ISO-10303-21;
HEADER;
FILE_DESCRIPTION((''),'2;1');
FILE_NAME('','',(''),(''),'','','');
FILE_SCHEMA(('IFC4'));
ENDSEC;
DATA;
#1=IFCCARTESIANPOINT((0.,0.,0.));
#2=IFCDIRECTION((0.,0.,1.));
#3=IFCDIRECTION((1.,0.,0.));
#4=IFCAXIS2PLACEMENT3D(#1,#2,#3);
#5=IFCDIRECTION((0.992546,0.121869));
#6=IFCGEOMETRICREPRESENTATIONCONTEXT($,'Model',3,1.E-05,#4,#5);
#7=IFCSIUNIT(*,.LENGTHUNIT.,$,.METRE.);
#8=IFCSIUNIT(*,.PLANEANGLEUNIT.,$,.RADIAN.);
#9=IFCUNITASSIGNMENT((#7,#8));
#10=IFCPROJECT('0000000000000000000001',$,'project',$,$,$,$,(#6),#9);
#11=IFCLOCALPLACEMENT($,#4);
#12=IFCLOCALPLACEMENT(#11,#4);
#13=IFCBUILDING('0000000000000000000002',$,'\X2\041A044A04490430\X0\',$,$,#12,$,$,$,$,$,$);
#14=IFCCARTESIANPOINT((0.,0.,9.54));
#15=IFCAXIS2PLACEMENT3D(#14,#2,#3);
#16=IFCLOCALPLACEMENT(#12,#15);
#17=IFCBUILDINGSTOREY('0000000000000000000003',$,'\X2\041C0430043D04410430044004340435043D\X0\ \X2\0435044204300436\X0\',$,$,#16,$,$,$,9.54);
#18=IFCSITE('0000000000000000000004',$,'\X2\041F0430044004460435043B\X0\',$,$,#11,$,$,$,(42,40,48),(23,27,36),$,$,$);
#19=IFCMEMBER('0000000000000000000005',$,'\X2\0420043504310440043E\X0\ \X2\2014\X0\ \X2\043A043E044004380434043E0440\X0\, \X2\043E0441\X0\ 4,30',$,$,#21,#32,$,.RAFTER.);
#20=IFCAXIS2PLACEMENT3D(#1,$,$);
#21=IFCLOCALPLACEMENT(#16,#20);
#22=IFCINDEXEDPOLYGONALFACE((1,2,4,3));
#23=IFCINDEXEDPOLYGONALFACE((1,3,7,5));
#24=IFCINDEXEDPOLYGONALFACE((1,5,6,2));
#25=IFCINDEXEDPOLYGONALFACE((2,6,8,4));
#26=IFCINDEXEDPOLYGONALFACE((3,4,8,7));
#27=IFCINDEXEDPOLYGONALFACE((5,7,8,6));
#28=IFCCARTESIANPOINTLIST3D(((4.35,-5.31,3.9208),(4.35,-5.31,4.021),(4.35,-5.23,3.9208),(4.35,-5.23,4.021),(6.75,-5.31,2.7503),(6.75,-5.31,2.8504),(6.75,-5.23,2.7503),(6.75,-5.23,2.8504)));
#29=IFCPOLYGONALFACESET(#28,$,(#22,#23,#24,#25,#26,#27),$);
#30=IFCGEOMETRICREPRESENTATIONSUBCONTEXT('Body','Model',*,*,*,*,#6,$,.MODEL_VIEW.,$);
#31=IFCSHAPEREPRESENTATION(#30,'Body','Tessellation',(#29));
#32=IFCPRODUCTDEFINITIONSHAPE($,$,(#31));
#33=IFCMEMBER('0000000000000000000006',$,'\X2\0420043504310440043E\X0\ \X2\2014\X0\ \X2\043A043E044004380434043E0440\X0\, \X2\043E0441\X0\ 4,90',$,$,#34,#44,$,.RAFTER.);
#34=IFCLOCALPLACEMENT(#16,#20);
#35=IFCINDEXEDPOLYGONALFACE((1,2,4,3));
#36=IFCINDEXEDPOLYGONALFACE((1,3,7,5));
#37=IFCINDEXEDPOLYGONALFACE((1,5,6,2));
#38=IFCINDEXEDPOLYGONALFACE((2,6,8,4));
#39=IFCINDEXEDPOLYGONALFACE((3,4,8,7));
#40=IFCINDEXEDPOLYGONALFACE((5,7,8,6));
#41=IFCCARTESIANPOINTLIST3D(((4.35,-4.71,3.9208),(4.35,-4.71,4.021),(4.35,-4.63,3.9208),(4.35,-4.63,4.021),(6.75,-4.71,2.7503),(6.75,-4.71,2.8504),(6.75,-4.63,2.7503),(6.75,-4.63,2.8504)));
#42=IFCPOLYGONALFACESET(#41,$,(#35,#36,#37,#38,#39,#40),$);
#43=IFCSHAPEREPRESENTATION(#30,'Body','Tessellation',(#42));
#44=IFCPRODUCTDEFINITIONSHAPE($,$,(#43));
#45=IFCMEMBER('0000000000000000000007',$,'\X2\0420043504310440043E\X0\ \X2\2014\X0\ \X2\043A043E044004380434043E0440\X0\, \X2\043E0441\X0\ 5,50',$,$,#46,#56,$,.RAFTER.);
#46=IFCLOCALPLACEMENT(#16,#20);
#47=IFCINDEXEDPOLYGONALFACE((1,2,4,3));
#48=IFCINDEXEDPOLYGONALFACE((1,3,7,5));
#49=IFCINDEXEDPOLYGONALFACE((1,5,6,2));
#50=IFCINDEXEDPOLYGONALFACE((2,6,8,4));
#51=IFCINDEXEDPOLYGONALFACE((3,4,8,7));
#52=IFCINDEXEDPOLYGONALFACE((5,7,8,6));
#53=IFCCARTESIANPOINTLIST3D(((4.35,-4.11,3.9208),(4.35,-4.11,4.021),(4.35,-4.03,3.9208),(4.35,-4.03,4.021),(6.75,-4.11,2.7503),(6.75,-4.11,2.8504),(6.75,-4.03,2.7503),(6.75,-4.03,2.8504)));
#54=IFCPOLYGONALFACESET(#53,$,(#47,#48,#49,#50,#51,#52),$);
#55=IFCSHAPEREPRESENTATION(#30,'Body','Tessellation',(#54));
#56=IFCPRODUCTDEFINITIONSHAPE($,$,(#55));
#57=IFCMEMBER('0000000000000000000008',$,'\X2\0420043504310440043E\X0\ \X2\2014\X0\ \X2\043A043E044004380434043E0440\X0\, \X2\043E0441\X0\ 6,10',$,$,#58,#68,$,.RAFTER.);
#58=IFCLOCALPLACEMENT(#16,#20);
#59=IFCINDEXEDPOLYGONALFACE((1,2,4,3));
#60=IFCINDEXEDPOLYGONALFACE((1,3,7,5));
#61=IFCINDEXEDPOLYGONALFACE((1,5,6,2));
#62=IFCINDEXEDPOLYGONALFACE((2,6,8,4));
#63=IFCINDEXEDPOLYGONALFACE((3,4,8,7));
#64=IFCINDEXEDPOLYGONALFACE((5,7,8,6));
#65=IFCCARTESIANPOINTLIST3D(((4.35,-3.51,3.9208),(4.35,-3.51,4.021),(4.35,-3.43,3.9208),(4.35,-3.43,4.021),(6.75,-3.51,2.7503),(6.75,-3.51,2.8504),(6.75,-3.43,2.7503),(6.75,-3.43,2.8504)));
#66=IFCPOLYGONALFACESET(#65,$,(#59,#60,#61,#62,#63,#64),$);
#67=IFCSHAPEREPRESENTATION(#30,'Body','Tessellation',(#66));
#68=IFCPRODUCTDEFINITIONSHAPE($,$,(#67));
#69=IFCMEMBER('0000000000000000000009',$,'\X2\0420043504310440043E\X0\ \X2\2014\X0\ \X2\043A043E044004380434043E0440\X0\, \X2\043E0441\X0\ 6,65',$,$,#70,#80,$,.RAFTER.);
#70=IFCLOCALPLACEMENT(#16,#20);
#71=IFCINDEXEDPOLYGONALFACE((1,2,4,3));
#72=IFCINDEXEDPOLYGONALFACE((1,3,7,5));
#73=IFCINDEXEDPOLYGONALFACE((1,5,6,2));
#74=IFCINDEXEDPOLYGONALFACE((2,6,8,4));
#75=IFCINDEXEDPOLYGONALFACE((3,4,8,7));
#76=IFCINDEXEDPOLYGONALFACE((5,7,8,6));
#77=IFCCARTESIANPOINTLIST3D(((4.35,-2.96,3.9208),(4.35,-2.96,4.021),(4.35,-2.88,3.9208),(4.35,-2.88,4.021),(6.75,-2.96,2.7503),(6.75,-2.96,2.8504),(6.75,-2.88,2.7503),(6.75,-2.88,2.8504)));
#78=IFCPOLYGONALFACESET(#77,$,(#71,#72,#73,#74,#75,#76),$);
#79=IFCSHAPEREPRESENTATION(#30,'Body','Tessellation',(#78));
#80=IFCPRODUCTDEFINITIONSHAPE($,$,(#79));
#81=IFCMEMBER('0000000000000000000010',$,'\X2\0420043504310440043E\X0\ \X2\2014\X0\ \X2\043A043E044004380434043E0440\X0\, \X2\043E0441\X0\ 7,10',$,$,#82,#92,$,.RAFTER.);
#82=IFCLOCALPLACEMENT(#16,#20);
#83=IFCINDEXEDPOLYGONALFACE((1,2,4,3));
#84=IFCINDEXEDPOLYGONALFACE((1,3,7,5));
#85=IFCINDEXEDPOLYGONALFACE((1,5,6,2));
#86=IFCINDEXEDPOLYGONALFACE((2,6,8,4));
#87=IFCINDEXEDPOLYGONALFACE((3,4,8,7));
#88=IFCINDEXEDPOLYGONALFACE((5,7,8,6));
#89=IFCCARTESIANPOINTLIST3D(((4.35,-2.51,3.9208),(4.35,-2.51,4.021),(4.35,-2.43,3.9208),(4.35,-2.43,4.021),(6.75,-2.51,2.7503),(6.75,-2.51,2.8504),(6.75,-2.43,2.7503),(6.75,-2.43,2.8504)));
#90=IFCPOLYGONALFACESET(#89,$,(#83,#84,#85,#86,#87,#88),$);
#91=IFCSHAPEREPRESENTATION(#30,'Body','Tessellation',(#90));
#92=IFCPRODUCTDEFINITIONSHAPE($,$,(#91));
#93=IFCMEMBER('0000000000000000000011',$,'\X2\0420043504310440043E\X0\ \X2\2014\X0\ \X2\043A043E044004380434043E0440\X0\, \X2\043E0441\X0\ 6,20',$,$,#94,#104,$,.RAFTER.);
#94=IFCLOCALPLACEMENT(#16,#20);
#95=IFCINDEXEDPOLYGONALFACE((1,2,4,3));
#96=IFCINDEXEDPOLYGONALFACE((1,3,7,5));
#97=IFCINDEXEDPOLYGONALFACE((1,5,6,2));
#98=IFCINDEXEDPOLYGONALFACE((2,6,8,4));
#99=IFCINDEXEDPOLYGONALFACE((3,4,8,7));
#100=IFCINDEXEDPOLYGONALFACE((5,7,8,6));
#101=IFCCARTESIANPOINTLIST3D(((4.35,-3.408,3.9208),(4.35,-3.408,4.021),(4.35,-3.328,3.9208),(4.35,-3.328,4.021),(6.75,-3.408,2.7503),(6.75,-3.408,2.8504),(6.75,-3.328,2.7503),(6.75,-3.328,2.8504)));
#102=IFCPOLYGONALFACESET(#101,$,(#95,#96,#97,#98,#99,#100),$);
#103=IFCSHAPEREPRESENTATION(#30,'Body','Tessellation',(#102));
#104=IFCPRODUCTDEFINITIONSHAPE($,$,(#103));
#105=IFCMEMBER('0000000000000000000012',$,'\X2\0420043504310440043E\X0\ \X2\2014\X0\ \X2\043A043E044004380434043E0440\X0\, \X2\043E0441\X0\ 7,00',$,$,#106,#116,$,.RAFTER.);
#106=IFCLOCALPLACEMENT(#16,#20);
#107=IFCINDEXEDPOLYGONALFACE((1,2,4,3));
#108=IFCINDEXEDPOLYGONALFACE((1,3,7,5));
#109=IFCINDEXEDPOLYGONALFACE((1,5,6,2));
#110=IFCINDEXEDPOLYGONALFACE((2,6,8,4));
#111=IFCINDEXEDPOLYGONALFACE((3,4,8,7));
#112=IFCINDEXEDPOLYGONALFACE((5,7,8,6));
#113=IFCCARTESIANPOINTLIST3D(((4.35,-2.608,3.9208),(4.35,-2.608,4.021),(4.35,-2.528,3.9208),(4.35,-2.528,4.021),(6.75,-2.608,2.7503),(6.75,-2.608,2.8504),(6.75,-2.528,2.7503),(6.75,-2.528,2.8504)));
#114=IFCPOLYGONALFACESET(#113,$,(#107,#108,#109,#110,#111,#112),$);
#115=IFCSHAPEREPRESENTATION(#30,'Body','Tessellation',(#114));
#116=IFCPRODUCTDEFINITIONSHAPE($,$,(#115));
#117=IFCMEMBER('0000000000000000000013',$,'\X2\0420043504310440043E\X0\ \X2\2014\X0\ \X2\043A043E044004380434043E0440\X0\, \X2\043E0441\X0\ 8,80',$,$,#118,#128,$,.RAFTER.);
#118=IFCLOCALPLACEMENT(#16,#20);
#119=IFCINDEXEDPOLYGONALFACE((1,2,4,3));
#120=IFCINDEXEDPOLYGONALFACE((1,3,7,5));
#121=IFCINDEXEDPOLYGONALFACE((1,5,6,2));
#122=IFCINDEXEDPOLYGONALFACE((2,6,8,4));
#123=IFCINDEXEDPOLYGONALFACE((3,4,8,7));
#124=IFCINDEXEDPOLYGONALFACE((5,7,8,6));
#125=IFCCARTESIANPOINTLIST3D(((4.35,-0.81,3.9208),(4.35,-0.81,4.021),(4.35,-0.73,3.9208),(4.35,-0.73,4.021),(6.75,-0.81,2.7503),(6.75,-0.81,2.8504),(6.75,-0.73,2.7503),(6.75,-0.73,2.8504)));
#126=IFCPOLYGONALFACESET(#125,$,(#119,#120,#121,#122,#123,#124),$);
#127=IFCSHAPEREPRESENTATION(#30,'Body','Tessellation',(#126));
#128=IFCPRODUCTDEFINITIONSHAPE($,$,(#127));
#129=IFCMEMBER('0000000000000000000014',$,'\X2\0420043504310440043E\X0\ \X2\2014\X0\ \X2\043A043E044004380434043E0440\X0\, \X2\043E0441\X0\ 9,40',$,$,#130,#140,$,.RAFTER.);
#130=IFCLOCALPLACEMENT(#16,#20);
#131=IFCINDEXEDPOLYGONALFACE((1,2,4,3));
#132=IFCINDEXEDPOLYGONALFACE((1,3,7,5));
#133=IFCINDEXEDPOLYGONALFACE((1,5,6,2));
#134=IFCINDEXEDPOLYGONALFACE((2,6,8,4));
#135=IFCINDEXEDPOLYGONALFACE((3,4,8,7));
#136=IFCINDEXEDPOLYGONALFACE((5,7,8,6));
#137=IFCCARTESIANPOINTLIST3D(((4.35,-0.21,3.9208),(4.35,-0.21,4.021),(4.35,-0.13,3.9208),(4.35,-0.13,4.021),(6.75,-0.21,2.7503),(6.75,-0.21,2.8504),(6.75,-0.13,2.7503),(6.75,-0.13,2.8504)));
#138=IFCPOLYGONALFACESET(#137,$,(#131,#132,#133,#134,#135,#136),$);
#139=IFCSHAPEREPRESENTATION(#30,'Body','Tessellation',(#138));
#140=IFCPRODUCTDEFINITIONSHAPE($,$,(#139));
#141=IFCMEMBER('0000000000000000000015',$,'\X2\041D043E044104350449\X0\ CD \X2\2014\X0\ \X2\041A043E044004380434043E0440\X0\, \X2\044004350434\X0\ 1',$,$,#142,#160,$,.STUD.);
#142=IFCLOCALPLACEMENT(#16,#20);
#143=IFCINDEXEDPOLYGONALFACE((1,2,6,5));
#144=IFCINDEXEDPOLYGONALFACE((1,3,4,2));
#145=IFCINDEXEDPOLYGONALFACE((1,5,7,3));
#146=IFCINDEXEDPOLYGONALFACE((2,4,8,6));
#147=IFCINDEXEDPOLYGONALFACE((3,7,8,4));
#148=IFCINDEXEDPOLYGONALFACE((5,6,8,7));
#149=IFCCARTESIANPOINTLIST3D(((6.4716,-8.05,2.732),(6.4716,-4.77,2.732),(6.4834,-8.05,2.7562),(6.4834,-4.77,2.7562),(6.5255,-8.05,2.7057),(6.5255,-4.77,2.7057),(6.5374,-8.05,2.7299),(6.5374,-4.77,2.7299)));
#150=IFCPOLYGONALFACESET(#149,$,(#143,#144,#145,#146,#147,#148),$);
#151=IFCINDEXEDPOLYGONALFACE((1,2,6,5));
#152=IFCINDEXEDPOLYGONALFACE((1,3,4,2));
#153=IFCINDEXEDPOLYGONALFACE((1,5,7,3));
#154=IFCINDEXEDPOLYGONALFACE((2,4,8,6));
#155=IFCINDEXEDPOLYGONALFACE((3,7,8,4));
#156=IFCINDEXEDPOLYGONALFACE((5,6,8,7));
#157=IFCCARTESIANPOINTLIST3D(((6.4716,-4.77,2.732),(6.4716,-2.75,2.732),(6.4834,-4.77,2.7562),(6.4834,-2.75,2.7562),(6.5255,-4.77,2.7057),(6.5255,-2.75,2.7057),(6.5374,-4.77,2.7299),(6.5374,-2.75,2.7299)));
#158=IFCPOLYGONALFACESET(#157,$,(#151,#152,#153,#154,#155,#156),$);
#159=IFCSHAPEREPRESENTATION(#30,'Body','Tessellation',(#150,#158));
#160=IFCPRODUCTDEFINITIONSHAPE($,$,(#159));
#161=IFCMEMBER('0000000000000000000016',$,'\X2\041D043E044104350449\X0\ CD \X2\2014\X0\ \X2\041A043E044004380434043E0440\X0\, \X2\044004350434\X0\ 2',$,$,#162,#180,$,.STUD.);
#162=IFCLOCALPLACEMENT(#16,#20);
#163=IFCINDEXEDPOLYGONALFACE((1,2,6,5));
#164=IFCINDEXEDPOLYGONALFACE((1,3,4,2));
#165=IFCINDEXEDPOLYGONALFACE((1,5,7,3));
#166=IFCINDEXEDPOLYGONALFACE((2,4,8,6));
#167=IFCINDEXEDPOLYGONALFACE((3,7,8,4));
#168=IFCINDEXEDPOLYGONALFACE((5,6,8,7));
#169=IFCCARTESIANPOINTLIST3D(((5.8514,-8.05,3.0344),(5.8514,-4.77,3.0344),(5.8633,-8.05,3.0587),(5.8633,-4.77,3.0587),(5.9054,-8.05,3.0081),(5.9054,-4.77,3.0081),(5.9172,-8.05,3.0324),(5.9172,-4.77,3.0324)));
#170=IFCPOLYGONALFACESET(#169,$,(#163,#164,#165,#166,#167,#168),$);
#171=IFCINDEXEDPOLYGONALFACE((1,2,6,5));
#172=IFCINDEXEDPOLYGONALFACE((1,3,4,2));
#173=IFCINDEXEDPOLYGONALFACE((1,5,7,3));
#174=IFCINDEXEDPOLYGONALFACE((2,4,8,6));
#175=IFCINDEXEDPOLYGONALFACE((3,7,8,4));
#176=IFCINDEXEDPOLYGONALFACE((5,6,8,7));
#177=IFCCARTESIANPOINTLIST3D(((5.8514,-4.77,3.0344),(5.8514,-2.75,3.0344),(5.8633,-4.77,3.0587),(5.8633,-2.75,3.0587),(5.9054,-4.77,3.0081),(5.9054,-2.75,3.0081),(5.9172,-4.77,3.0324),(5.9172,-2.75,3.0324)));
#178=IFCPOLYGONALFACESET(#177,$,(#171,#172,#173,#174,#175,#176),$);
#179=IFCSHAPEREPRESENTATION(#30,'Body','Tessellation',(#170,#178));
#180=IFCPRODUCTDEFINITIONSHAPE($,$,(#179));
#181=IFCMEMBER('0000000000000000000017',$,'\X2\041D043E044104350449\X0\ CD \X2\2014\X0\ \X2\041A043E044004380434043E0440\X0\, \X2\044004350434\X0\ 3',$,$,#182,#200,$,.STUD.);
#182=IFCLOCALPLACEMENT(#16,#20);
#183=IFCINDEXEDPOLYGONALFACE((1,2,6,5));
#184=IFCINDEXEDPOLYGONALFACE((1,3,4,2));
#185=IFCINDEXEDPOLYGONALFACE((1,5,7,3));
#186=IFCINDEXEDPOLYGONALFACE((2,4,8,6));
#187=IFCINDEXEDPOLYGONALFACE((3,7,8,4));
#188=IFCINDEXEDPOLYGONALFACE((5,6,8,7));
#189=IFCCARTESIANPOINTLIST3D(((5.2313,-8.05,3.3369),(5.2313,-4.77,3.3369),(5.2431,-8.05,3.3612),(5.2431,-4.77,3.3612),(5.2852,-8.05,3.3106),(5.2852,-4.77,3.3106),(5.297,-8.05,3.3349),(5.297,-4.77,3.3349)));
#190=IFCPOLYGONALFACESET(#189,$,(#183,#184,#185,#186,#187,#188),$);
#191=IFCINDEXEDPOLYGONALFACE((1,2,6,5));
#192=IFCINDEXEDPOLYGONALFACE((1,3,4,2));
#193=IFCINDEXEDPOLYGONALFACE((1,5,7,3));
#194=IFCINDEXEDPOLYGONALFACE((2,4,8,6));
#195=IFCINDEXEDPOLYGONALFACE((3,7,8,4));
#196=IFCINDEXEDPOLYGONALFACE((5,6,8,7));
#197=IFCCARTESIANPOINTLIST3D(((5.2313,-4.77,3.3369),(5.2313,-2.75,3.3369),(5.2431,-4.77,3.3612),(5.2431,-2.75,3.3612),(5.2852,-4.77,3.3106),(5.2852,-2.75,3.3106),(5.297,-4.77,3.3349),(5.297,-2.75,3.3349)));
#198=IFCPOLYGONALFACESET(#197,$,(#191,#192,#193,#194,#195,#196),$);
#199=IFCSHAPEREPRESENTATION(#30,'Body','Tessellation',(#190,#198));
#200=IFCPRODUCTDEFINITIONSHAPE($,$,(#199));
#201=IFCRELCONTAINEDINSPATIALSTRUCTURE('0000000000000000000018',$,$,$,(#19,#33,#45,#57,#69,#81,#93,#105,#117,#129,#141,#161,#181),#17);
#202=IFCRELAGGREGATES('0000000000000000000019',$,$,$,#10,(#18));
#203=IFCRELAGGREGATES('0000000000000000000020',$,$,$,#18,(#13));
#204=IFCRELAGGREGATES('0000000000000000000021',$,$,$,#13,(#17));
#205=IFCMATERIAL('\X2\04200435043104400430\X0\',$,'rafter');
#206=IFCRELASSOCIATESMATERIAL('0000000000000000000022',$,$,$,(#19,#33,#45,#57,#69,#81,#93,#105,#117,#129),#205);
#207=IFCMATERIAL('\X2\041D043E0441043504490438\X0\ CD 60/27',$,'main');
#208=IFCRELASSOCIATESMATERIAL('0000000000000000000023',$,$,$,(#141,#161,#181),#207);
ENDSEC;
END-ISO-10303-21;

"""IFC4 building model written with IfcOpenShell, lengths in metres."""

from ifc_helpers import new_model, si_unit, direction, frame, origin_with_axes, place, context, subcontext, project, spatial, polyline, outline, extrude, material, element, save


model = new_model("IFC4")

# Units and contexts
model_context = context("Model", 3, precision=1e-05, world=origin_with_axes(), true_north=direction((0.992546, 0.121869)))
body_context = subcontext(model_context, "Body", "Model", "MODEL_VIEW")
ifc_project = project(units=[si_unit("LENGTHUNIT", "METRE"), si_unit("PLANEANGLEUNIT", "RADIAN")], contexts=[model_context])

# Site, building, storey
site_placement = place(None, origin_with_axes())
site = spatial("IfcSite", under=ifc_project, at=site_placement, Name="Парцел", RefLatitude=(42, 40, 48), RefLongitude=(23, 27, 36))
building_placement = place(site_placement, origin_with_axes())
building = spatial("IfcBuilding", under=site, at=building_placement, Name="Къща")
storey_placement = place(building_placement, frame((0.0, 0.0, 9.54), z_axis=(0.0, 0.0, 1.0), x_axis=(1.0, 0.0, 0.0)))
storey = spatial("IfcBuildingStorey", under=building, at=storey_placement, Name="Мансарден етаж", Elevation=9.54)

# Members
ifc_material_1 = material(Name="Ребра", Category="rafter")
member_1_placement = place(storey_placement, origin_with_axes())
element("IfcMember", 1, at=member_1_placement, inside=storey, material=ifc_material_1, Name="Ребро — коридор, ос 4,30", PredefinedType="RAFTER", context=body_context, shape_type="SweptSolid", body=[
    extrude(outline(polyline([(6.75, -2.7503), (4.35, -3.9208), (4.35, -4.021), (6.75, -2.8504), (6.75, -2.7503)])), frame((0.0, -5.31, 0.0), z_axis=(0.0, 1.0, 0.0), x_axis=(1.0, 0.0, 0.0)), (0.0, 0.0, 1.0), 0.08),
])
member_2_placement = place(storey_placement, origin_with_axes())
element("IfcMember", 2, at=member_2_placement, inside=storey, material=ifc_material_1, Name="Ребро — коридор, ос 4,90", PredefinedType="RAFTER", context=body_context, shape_type="SweptSolid", body=[
    extrude(outline(polyline([(6.75, -2.7503), (4.35, -3.9208), (4.35, -4.021), (6.75, -2.8504), (6.75, -2.7503)])), frame((0.0, -4.71, 0.0), z_axis=(0.0, 1.0, 0.0), x_axis=(1.0, 0.0, 0.0)), (0.0, 0.0, 1.0), 0.08),
])
member_3_placement = place(storey_placement, origin_with_axes())
element("IfcMember", 3, at=member_3_placement, inside=storey, material=ifc_material_1, Name="Ребро — коридор, ос 5,50", PredefinedType="RAFTER", context=body_context, shape_type="SweptSolid", body=[
    extrude(outline(polyline([(6.75, -2.7503), (4.35, -3.9208), (4.35, -4.021), (6.75, -2.8504), (6.75, -2.7503)])), frame((0.0, -4.11, 0.0), z_axis=(0.0, 1.0, 0.0), x_axis=(1.0, 0.0, 0.0)), (0.0, 0.0, 1.0), 0.08),
])
member_4_placement = place(storey_placement, origin_with_axes())
element("IfcMember", 4, at=member_4_placement, inside=storey, material=ifc_material_1, Name="Ребро — коридор, ос 6,10", PredefinedType="RAFTER", context=body_context, shape_type="SweptSolid", body=[
    extrude(outline(polyline([(6.75, -2.7503), (4.35, -3.9208), (4.35, -4.021), (6.75, -2.8504), (6.75, -2.7503)])), frame((0.0, -3.51, 0.0), z_axis=(0.0, 1.0, 0.0), x_axis=(1.0, 0.0, 0.0)), (0.0, 0.0, 1.0), 0.08),
])
member_5_placement = place(storey_placement, origin_with_axes())
element("IfcMember", 5, at=member_5_placement, inside=storey, material=ifc_material_1, Name="Ребро — коридор, ос 6,65", PredefinedType="RAFTER", context=body_context, shape_type="SweptSolid", body=[
    extrude(outline(polyline([(6.75, -2.7503), (4.35, -3.9208), (4.35, -4.021), (6.75, -2.8504), (6.75, -2.7503)])), frame((0.0, -2.96, 0.0), z_axis=(0.0, 1.0, 0.0), x_axis=(1.0, 0.0, 0.0)), (0.0, 0.0, 1.0), 0.08),
])
member_6_placement = place(storey_placement, origin_with_axes())
element("IfcMember", 6, at=member_6_placement, inside=storey, material=ifc_material_1, Name="Ребро — коридор, ос 7,10", PredefinedType="RAFTER", context=body_context, shape_type="SweptSolid", body=[
    extrude(outline(polyline([(6.75, -2.7503), (4.35, -3.9208), (4.35, -4.021), (6.75, -2.8504), (6.75, -2.7503)])), frame((0.0, -2.51, 0.0), z_axis=(0.0, 1.0, 0.0), x_axis=(1.0, 0.0, 0.0)), (0.0, 0.0, 1.0), 0.08),
])
member_7_placement = place(storey_placement, origin_with_axes())
element("IfcMember", 7, at=member_7_placement, inside=storey, material=ifc_material_1, Name="Ребро — коридор, ос 6,20", PredefinedType="RAFTER", context=body_context, shape_type="SweptSolid", body=[
    extrude(outline(polyline([(6.75, -2.7503), (4.35, -3.9208), (4.35, -4.021), (6.75, -2.8504), (6.75, -2.7503)])), frame((0.0, -3.408, 0.0), z_axis=(0.0, 1.0, 0.0), x_axis=(1.0, 0.0, 0.0)), (0.0, 0.0, 1.0), 0.08),
])
member_8_placement = place(storey_placement, origin_with_axes())
element("IfcMember", 8, at=member_8_placement, inside=storey, material=ifc_material_1, Name="Ребро — коридор, ос 7,00", PredefinedType="RAFTER", context=body_context, shape_type="SweptSolid", body=[
    extrude(outline(polyline([(6.75, -2.7503), (4.35, -3.9208), (4.35, -4.021), (6.75, -2.8504), (6.75, -2.7503)])), frame((0.0, -2.608, 0.0), z_axis=(0.0, 1.0, 0.0), x_axis=(1.0, 0.0, 0.0)), (0.0, 0.0, 1.0), 0.08),
])
member_9_placement = place(storey_placement, origin_with_axes())
element("IfcMember", 9, at=member_9_placement, inside=storey, material=ifc_material_1, Name="Ребро — коридор, ос 8,80", PredefinedType="RAFTER", context=body_context, shape_type="SweptSolid", body=[
    extrude(outline(polyline([(6.75, -2.7503), (4.35, -3.9208), (4.35, -4.021), (6.75, -2.8504), (6.75, -2.7503)])), frame((0.0, -0.81, 0.0), z_axis=(0.0, 1.0, 0.0), x_axis=(1.0, 0.0, 0.0)), (0.0, 0.0, 1.0), 0.08),
])
member_10_placement = place(storey_placement, origin_with_axes())
element("IfcMember", 10, at=member_10_placement, inside=storey, material=ifc_material_1, Name="Ребро — коридор, ос 9,40", PredefinedType="RAFTER", context=body_context, shape_type="SweptSolid", body=[
    extrude(outline(polyline([(6.75, -2.7503), (4.35, -3.9208), (4.35, -4.021), (6.75, -2.8504), (6.75, -2.7503)])), frame((0.0, -0.21, 0.0), z_axis=(0.0, 1.0, 0.0), x_axis=(1.0, 0.0, 0.0)), (0.0, 0.0, 1.0), 0.08),
])
ifc_material_2 = material(Name="Носещи CD 60/27", Category="main")
member_11_placement = place(storey_placement, origin_with_axes())
element("IfcMember", 11, at=member_11_placement, inside=storey, material=ifc_material_2, Name="Носещ CD — Коридор, ред 1", PredefinedType="STUD", context=body_context, shape_type="SweptSolid", body=[
    extrude(outline(polyline([(6.5255, -2.7057), (6.4716, -2.732), (6.4834, -2.7562), (6.5374, -2.7299), (6.5255, -2.7057)])), frame((0.0, -8.05, 0.0), z_axis=(0.0, 1.0, 0.0), x_axis=(1.0, 0.0, 0.0)), (0.0, 0.0, 1.0), 3.28),
    extrude(outline(polyline([(6.5255, -2.7057), (6.4716, -2.732), (6.4834, -2.7562), (6.5374, -2.7299), (6.5255, -2.7057)])), frame((0.0, -4.77, 0.0), z_axis=(0.0, 1.0, 0.0), x_axis=(1.0, 0.0, 0.0)), (0.0, 0.0, 1.0), 2.02),
])
member_12_placement = place(storey_placement, origin_with_axes())
element("IfcMember", 12, at=member_12_placement, inside=storey, material=ifc_material_2, Name="Носещ CD — Коридор, ред 2", PredefinedType="STUD", context=body_context, shape_type="SweptSolid", body=[
    extrude(outline(polyline([(5.9054, -3.0081), (5.8514, -3.0344), (5.8633, -3.0587), (5.9172, -3.0324), (5.9054, -3.0081)])), frame((0.0, -8.05, 0.0), z_axis=(0.0, 1.0, 0.0), x_axis=(1.0, 0.0, 0.0)), (0.0, 0.0, 1.0), 3.28),
    extrude(outline(polyline([(5.9054, -3.0081), (5.8514, -3.0344), (5.8633, -3.0587), (5.9172, -3.0324), (5.9054, -3.0081)])), frame((0.0, -4.77, 0.0), z_axis=(0.0, 1.0, 0.0), x_axis=(1.0, 0.0, 0.0)), (0.0, 0.0, 1.0), 2.02),
])
member_13_placement = place(storey_placement, origin_with_axes())
element("IfcMember", 13, at=member_13_placement, inside=storey, material=ifc_material_2, Name="Носещ CD — Коридор, ред 3", PredefinedType="STUD", context=body_context, shape_type="SweptSolid", body=[
    extrude(outline(polyline([(5.2852, -3.3106), (5.2313, -3.3369), (5.2431, -3.3612), (5.297, -3.3349), (5.2852, -3.3106)])), frame((0.0, -8.05, 0.0), z_axis=(0.0, 1.0, 0.0), x_axis=(1.0, 0.0, 0.0)), (0.0, 0.0, 1.0), 3.28),
    extrude(outline(polyline([(5.2852, -3.3106), (5.2313, -3.3369), (5.2431, -3.3612), (5.297, -3.3349), (5.2852, -3.3106)])), frame((0.0, -4.77, 0.0), z_axis=(0.0, 1.0, 0.0), x_axis=(1.0, 0.0, 0.0)), (0.0, 0.0, 1.0), 2.02),
])

save(model, "model.ifc")
